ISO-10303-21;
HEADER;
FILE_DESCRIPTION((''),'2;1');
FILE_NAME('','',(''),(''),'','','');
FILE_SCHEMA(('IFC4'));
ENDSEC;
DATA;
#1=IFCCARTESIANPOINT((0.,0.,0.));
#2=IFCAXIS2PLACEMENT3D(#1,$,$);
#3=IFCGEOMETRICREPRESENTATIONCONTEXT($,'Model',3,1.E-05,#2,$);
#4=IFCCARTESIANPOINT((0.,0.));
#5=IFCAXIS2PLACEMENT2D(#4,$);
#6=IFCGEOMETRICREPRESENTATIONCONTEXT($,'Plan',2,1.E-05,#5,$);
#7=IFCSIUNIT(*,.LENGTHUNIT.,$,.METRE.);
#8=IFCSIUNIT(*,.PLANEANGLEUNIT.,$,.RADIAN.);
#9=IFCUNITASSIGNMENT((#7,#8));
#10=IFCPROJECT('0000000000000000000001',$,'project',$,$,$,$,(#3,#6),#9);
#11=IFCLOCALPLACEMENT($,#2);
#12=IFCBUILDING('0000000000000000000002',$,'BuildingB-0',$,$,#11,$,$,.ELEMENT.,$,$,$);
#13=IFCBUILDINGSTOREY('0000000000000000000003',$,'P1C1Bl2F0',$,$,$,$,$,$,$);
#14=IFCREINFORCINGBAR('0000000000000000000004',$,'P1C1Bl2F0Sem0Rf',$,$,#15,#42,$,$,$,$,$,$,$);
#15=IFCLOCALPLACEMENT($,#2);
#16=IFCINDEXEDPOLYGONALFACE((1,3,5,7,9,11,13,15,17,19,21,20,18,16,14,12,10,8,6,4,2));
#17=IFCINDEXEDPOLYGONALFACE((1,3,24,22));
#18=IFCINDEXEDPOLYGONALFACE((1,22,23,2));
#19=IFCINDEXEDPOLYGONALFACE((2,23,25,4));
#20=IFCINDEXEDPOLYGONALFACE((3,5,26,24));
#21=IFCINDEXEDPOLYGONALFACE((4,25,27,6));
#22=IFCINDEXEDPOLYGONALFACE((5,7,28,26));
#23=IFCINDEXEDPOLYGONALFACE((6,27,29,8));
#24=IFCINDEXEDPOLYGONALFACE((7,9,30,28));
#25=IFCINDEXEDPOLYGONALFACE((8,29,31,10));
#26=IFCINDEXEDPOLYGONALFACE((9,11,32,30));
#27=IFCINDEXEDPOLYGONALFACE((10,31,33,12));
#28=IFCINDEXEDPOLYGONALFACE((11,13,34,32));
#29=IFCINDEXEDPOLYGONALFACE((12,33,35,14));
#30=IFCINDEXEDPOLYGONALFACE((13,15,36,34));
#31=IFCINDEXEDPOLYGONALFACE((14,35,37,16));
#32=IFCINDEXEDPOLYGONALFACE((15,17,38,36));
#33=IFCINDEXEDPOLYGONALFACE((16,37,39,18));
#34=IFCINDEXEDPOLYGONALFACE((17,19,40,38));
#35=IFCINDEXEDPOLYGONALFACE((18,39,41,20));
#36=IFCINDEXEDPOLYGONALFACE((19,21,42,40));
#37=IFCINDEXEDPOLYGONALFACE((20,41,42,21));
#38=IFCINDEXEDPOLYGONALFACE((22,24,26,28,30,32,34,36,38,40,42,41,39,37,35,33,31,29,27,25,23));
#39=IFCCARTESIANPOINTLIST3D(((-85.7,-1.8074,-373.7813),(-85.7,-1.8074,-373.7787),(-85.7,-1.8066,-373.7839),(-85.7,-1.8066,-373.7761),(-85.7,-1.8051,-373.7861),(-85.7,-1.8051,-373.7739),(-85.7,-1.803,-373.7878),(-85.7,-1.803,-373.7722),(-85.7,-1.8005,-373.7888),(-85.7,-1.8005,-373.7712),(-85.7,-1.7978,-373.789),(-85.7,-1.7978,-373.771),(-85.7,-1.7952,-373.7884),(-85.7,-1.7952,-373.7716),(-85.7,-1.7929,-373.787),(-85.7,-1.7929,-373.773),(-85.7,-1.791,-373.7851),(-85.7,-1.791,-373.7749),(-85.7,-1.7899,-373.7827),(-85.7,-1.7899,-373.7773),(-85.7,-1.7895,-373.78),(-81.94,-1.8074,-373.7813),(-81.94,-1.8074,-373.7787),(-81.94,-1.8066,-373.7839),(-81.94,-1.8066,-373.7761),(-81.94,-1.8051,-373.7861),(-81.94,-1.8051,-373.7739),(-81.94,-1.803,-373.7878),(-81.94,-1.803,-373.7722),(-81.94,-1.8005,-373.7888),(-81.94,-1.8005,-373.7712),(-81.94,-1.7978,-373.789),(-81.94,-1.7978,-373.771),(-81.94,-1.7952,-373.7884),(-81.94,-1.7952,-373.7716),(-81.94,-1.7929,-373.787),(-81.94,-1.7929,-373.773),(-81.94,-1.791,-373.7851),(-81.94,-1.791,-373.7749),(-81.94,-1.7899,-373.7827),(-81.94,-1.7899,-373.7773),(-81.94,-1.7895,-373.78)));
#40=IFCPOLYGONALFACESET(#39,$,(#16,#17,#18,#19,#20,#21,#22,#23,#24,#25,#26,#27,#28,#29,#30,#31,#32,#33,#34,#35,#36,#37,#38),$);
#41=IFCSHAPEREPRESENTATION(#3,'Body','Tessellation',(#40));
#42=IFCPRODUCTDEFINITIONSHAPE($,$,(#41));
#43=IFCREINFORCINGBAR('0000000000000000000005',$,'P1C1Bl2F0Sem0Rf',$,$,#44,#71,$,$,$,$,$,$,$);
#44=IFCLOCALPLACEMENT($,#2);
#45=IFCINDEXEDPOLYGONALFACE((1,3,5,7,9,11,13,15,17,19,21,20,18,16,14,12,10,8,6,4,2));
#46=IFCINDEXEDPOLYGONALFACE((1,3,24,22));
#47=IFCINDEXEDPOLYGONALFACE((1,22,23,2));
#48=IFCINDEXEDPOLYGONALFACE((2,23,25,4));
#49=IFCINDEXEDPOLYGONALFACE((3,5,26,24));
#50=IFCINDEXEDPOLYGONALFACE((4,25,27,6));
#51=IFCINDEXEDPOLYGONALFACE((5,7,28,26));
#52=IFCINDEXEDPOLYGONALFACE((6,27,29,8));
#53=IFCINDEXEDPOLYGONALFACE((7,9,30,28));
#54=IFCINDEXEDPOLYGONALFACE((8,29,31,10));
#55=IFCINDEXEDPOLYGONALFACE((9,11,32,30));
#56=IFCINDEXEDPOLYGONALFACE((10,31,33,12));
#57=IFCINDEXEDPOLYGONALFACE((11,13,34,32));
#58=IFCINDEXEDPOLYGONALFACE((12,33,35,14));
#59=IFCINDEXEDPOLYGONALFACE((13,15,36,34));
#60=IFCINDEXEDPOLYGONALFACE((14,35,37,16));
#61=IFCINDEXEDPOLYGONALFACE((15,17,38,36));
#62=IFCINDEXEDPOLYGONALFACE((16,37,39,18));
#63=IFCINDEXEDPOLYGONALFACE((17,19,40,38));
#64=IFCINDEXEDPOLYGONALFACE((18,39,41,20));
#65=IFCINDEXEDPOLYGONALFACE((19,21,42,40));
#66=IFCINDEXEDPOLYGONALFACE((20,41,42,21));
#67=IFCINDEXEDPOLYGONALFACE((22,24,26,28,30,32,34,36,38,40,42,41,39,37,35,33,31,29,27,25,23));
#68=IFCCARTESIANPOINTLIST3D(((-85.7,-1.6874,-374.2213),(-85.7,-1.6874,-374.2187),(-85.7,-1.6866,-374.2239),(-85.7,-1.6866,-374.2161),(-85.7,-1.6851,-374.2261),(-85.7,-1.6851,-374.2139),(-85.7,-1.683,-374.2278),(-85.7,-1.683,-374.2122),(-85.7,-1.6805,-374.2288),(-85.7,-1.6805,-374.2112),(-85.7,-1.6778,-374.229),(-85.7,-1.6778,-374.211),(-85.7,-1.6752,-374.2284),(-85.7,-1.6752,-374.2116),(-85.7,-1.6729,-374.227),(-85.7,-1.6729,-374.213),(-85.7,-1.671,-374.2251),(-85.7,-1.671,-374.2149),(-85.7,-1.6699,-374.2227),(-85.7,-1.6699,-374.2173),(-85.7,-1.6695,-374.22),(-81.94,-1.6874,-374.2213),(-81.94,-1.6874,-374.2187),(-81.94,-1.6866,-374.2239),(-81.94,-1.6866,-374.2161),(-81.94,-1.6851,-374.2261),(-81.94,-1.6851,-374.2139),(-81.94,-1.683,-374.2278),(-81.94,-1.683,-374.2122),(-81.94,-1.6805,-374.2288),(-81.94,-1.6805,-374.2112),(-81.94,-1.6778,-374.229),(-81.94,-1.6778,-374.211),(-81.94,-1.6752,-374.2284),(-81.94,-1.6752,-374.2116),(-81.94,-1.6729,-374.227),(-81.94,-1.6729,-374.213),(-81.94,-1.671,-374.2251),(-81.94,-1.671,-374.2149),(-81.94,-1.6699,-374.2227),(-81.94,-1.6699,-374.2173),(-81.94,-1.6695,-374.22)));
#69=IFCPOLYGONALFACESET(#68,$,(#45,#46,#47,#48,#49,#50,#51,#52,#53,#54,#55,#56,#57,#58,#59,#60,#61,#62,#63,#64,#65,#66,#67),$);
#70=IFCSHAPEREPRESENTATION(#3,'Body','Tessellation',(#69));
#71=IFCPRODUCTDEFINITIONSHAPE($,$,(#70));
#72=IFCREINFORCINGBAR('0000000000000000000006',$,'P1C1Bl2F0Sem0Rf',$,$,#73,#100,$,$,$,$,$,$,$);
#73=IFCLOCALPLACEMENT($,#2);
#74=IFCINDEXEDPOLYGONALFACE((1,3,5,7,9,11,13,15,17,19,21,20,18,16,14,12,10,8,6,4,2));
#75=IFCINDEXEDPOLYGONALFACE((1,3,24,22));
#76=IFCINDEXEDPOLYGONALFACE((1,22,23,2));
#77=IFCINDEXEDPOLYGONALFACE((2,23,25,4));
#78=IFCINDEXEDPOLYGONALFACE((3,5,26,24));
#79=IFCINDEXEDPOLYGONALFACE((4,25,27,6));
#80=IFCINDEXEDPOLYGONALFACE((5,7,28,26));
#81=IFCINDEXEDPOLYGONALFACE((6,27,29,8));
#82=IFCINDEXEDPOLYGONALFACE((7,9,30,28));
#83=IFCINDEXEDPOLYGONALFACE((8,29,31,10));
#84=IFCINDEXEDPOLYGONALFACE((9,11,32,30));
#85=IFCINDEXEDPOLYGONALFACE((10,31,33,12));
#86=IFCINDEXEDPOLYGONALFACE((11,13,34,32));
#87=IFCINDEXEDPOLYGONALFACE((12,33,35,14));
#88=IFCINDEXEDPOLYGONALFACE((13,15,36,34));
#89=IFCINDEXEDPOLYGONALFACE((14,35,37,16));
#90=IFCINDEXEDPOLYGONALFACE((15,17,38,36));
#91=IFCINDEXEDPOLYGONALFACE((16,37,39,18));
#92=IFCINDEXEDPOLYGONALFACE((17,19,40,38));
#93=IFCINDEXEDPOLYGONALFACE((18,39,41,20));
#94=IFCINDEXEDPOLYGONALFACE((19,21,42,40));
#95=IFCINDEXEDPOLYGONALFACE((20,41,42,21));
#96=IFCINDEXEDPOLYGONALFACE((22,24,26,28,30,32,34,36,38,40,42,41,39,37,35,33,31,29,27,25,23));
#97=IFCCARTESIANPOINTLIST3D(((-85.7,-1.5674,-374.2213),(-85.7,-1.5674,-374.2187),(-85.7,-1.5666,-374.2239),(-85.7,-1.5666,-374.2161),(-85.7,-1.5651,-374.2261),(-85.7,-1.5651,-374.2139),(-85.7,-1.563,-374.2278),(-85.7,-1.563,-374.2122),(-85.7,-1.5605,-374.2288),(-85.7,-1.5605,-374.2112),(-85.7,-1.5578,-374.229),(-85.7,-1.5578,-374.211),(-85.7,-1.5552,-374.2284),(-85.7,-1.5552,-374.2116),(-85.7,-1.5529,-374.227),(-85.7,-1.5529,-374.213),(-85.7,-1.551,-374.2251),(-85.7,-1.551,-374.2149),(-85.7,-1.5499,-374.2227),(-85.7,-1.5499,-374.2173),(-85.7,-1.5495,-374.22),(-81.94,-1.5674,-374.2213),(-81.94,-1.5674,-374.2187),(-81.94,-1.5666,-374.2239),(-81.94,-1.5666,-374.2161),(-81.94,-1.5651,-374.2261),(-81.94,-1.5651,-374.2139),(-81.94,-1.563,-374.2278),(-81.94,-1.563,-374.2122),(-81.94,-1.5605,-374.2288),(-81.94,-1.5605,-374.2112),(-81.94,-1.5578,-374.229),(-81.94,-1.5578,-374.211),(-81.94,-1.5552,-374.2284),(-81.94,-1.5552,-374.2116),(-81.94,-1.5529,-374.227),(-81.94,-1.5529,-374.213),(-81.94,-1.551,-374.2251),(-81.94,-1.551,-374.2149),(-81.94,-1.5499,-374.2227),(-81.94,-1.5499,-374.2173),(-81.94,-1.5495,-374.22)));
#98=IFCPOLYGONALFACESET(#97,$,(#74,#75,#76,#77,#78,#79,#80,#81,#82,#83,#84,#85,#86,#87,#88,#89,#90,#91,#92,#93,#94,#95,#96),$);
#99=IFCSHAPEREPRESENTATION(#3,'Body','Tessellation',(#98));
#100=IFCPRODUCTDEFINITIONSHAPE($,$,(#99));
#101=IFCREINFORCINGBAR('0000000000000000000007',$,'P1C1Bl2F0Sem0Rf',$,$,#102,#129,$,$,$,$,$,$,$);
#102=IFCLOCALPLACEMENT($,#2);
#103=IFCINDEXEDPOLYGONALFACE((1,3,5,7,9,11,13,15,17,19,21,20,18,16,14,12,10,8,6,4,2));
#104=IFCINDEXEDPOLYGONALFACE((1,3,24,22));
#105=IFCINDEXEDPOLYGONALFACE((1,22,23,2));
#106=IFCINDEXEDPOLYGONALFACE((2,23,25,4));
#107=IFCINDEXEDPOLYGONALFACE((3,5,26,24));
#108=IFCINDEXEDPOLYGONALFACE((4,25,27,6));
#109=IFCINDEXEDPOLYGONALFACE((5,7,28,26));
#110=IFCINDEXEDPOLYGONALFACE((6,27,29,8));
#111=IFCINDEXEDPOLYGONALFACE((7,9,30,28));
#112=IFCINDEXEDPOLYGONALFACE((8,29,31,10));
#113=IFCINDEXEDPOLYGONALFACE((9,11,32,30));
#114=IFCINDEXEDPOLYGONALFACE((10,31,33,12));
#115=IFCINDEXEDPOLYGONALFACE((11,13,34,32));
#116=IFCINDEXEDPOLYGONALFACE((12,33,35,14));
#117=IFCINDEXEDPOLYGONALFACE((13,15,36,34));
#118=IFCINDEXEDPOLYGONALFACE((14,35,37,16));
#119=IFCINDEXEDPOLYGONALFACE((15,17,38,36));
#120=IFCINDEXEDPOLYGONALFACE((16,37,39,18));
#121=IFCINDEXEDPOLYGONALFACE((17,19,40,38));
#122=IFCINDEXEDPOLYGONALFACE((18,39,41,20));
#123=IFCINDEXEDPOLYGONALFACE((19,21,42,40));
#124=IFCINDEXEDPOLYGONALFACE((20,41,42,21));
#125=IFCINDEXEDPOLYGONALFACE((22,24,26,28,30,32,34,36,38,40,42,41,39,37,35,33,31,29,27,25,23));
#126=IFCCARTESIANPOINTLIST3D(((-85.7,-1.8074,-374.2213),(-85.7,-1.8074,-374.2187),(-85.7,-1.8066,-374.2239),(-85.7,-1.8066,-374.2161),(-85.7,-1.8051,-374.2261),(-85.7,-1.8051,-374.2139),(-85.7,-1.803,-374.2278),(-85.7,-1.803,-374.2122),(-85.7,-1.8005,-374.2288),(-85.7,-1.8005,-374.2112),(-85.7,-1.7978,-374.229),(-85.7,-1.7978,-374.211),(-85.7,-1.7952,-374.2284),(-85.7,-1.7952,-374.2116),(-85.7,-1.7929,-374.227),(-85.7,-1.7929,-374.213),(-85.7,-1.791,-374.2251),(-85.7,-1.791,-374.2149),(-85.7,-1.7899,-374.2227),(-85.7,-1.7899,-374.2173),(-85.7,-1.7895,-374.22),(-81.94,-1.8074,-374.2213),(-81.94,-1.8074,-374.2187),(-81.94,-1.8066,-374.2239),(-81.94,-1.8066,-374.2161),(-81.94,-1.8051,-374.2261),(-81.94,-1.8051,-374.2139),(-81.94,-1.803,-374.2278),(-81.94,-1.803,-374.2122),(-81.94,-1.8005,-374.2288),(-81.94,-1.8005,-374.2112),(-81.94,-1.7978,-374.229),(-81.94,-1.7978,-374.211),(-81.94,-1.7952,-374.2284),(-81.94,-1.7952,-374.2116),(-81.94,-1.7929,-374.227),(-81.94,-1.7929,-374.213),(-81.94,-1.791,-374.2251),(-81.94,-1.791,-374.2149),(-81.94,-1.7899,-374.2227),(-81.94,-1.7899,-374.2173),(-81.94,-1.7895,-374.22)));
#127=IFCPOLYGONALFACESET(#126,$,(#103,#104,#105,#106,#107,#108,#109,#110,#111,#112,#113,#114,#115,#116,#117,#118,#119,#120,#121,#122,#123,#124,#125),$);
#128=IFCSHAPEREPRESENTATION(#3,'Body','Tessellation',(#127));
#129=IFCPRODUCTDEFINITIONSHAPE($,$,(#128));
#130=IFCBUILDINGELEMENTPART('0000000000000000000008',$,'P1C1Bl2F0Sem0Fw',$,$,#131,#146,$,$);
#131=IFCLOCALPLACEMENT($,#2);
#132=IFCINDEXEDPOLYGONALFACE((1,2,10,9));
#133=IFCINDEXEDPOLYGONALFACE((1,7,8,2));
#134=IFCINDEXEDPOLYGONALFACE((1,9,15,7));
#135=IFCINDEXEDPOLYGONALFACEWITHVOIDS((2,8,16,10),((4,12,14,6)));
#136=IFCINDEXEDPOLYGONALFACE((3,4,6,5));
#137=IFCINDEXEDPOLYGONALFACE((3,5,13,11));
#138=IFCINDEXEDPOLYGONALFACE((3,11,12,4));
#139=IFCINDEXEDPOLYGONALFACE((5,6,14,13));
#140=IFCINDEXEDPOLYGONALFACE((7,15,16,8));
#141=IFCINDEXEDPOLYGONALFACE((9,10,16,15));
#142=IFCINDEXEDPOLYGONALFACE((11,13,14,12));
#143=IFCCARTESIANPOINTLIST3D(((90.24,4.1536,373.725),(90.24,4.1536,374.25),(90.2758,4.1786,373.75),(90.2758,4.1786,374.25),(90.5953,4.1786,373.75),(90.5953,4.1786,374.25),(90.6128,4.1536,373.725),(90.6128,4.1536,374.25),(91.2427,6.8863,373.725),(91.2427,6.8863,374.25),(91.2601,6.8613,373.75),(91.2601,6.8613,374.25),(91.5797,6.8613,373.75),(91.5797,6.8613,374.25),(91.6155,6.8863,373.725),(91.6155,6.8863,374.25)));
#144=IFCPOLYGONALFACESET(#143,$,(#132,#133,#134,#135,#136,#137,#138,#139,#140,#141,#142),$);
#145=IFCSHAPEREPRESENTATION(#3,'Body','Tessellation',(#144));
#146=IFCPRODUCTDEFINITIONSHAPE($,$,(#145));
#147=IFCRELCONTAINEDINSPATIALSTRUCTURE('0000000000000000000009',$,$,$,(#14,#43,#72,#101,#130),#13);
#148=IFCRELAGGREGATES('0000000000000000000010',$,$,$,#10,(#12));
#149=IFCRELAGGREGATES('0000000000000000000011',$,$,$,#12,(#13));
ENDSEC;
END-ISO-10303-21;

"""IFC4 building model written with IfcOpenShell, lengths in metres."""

from ifc_helpers import new_model, entity, si_unit, origin, origin_2d, place, context, project, spatial, polyline, outline, extrude, element, save


model = new_model("IFC4")

# Units and contexts
model_context = context("Model", 3, precision=1e-05, world=origin())
plan_context = context("Plan", 2, precision=1e-05, world=origin_2d())
ifc_project = project(units=[si_unit("LENGTHUNIT", "METRE"), si_unit("PLANEANGLEUNIT", "RADIAN")], contexts=[model_context, plan_context])

# Building, storey
building_placement = place(None, origin())
building = spatial("IfcBuilding", under=ifc_project, at=building_placement, Name="BuildingB-0", CompositionType="ELEMENT")
storey = spatial("IfcBuildingStorey", under=building, Name="P1C1Bl2F0")

# Reinforcing bars
element("IfcReinforcingBar", 1, inside=storey, Name="P1C1Bl2F0Sem0Rf", context=model_context, shape_type="SweptSolid", body=[
    entity("IfcSurfaceCurveSweptAreaSolid", entity("IfcCircleProfileDef", "AREA", None, None, 0.009), None, entity("IfcPolyline", [entity("IfcCartesianPoint", [81.94, 1.7985, 373.78]), entity("IfcCartesianPoint", [85.7, 1.7985, 373.78])]), None, None, entity("IfcPlane", entity("IfcAxis2Placement3D", entity("IfcCartesianPoint", [81.94, 1.7985, 373.78]), entity("IfcDirection", [0.0, 0.0, 1.0]), entity("IfcDirection", [1.0, 0.0, 0.0])))),
])
element("IfcReinforcingBar", 2, inside=storey, Name="P1C1Bl2F0Sem0Rf", context=model_context, shape_type="SweptSolid", body=[
    entity("IfcSurfaceCurveSweptAreaSolid", entity("IfcCircleProfileDef", "AREA", None, None, 0.009), None, entity("IfcPolyline", [entity("IfcCartesianPoint", [81.94, 1.6785, 374.22]), entity("IfcCartesianPoint", [85.7, 1.6785, 374.22])]), None, None, entity("IfcPlane", entity("IfcAxis2Placement3D", entity("IfcCartesianPoint", [81.94, 1.6785, 374.22]), entity("IfcDirection", [0.0, 0.0, 1.0]), entity("IfcDirection", [1.0, 0.0, 0.0])))),
])
element("IfcReinforcingBar", 3, inside=storey, Name="P1C1Bl2F0Sem0Rf", context=model_context, shape_type="SweptSolid", body=[
    entity("IfcSurfaceCurveSweptAreaSolid", entity("IfcCircleProfileDef", "AREA", None, None, 0.009), None, entity("IfcPolyline", [entity("IfcCartesianPoint", [81.94, 1.5585, 374.22]), entity("IfcCartesianPoint", [85.7, 1.5585, 374.22])]), None, None, entity("IfcPlane", entity("IfcAxis2Placement3D", entity("IfcCartesianPoint", [81.94, 1.5585, 374.22]), entity("IfcDirection", [0.0, 0.0, 1.0]), entity("IfcDirection", [1.0, 0.0, 0.0])))),
])
element("IfcReinforcingBar", 4, inside=storey, Name="P1C1Bl2F0Sem0Rf", context=model_context, shape_type="SweptSolid", body=[
    entity("IfcSurfaceCurveSweptAreaSolid", entity("IfcCircleProfileDef", "AREA", None, None, 0.009), None, entity("IfcPolyline", [entity("IfcCartesianPoint", [81.94, 1.7985, 374.22]), entity("IfcCartesianPoint", [85.7, 1.7985, 374.22])]), None, None, entity("IfcPlane", entity("IfcAxis2Placement3D", entity("IfcCartesianPoint", [81.94, 1.7985, 374.22]), entity("IfcDirection", [0.0, 0.0, 1.0]), entity("IfcDirection", [1.0, 0.0, 0.0])))),
])

# Building element part, opening
building_element_part_1 = element("IfcBuildingElementPart", 5, inside=storey, Name="P1C1Bl2F0Sem0Fw", context=model_context, shape_type="SweptSolid", body=[
    extrude(outline(polyline([(90.6128, 4.1536, 373.725), (90.24, 4.1536, 373.725), (91.2427, 6.8863, 373.725), (91.6155, 6.8863, 373.725), (90.6128, 4.1536, 373.725)])), None, (0.0, 0.0, 1.0), 0.525),
])
element("IfcOpeningElement", 6, inside=storey, cuts=building_element_part_1, context=model_context, shape_type="SweptSolid", body=[
    extrude(outline(polyline([(90.5953, 4.1786, 373.75), (90.2758, 4.1786, 373.75), (91.2601, 6.8613, 373.75), (91.5797, 6.8613, 373.75), (90.5953, 4.1786, 373.75)])), None, (0.0, 0.0, 1.0), 0.5),
])

save(model, "model.ifc")
